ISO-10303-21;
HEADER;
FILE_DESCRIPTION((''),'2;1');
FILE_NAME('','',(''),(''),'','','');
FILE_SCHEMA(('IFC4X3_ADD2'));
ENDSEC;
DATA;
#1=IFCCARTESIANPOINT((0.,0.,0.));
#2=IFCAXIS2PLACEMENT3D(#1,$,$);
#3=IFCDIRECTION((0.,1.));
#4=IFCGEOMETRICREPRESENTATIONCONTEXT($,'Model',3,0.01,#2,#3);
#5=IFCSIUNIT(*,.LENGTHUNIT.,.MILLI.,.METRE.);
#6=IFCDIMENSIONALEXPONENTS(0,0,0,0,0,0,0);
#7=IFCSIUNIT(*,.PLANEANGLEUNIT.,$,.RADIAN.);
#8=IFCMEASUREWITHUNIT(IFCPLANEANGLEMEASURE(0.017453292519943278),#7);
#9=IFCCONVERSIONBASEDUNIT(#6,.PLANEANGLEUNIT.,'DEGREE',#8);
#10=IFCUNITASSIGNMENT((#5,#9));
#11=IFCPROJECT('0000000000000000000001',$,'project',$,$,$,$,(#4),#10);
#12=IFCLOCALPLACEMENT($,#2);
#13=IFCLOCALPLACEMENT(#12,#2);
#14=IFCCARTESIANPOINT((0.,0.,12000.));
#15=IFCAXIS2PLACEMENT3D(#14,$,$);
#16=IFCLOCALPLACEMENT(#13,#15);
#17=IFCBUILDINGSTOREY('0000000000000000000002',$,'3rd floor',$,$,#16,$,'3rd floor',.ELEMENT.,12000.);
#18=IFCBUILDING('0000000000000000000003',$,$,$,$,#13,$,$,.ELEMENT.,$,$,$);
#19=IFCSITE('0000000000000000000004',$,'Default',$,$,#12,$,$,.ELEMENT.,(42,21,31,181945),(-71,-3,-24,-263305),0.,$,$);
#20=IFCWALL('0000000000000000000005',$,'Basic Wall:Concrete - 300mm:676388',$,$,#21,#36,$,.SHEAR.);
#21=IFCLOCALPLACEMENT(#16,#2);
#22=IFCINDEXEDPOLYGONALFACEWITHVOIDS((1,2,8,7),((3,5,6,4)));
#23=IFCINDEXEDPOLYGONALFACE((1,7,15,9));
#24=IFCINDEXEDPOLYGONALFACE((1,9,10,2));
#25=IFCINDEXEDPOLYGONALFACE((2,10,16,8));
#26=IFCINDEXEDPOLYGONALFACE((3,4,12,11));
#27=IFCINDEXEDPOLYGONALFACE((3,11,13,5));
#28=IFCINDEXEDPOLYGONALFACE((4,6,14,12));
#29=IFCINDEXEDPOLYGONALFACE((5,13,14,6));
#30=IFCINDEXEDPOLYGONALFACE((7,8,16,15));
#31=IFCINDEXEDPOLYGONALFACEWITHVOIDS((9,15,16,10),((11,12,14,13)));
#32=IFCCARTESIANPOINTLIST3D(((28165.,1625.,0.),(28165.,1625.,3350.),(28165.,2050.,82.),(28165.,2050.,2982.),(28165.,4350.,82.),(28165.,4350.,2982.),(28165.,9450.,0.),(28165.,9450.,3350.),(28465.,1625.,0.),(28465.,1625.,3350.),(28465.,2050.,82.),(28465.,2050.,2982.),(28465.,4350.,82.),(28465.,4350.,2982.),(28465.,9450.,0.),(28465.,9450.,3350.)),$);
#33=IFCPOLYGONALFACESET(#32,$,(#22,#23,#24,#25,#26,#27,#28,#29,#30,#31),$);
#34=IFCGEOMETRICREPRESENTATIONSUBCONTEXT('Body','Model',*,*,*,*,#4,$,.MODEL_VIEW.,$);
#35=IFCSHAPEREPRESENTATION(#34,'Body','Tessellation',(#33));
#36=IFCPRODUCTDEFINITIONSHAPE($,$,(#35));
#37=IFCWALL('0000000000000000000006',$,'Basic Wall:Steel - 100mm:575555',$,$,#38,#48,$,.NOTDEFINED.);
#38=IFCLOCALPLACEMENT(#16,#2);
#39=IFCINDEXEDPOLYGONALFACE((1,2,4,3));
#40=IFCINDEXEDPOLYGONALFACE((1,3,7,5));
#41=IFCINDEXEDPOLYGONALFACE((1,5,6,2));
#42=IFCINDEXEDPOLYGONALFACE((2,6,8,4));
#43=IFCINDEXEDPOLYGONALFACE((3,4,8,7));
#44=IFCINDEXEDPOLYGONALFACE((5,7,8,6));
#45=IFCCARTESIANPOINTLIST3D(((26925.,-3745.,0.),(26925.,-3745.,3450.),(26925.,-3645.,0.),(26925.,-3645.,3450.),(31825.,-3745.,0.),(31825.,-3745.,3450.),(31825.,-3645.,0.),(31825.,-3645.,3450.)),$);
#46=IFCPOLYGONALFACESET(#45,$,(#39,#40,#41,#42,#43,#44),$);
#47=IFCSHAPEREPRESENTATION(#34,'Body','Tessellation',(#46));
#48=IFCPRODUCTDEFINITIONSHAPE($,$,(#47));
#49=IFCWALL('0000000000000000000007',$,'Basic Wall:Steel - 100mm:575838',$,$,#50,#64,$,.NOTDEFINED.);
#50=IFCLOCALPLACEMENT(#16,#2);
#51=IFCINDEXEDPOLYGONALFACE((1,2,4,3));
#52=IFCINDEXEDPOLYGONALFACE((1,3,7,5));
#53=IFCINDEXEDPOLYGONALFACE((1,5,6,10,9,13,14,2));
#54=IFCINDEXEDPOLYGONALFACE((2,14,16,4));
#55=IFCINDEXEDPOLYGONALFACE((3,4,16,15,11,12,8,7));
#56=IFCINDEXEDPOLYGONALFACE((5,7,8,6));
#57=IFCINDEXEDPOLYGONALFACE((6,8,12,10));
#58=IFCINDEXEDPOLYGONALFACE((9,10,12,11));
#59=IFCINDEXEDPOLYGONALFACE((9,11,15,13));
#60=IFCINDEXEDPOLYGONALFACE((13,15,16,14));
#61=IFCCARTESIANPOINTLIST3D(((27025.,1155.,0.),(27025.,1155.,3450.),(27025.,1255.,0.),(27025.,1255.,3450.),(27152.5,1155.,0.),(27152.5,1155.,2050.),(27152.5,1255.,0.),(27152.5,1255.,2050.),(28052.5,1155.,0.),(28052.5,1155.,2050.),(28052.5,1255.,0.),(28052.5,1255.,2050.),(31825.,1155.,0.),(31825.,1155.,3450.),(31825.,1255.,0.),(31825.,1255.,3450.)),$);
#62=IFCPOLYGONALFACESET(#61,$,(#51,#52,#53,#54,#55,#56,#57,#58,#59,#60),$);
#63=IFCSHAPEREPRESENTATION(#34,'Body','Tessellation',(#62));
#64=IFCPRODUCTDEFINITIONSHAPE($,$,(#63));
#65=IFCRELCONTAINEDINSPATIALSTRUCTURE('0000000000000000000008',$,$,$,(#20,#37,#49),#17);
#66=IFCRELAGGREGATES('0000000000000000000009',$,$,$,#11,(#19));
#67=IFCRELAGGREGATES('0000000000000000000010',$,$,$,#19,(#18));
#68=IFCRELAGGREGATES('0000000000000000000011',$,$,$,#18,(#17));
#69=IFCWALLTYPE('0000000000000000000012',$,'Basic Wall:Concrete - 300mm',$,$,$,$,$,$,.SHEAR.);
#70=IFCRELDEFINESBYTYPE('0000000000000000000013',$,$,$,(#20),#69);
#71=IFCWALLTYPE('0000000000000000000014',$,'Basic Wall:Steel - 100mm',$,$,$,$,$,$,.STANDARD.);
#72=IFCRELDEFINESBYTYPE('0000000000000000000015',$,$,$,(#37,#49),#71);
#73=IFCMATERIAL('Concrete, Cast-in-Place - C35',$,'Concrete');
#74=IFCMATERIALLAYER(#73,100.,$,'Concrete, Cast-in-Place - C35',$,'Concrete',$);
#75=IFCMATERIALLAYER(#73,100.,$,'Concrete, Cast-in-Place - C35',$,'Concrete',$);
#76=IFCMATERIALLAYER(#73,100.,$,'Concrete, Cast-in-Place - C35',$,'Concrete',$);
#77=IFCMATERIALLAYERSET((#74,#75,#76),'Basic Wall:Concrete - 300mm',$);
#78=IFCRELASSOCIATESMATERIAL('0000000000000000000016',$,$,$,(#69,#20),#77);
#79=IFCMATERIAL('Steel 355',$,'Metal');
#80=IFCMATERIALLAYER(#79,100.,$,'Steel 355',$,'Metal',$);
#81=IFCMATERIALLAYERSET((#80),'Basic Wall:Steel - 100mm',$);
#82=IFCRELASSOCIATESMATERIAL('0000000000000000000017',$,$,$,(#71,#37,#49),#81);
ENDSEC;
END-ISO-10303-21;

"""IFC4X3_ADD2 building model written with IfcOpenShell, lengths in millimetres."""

from ifc_helpers import new_model, entity, si_unit, converted_unit, direction, frame, frame_2d, origin, place, context, subcontext, project, spatial, rectangle, extrude, material, layer, layer_set, type_object, element, save


model = new_model("IFC4X3_ADD2")

# Units and contexts
model_context = context("Model", 3, precision=0.01, world=origin(), true_north=direction((0.0, 1.0)))
body_context = subcontext(model_context, "Body", "Model", "MODEL_VIEW")
ifc_project = project(units=[si_unit("LENGTHUNIT", "METRE", prefix="MILLI"), converted_unit("PLANEANGLEUNIT", "DEGREE", entity("IfcPlaneAngleMeasure", 0.017453292519943278), si_unit("PLANEANGLEUNIT", "RADIAN"), dimensions=[0, 0, 0, 0, 0, 0, 0])], contexts=[model_context])

# Site, building, storey
site_placement = place(None, origin())
site = spatial("IfcSite", under=ifc_project, at=site_placement, Name="Default", CompositionType="ELEMENT", RefLatitude=(42, 21, 31, 181945), RefLongitude=(-71, -3, -24, -263305), RefElevation=0.0)
building_placement = place(site_placement, origin())
building = spatial("IfcBuilding", under=site, at=building_placement, CompositionType="ELEMENT")
storey_placement = place(building_placement, frame((0.0, 0.0, 12000.0)))
storey = spatial("IfcBuildingStorey", under=building, at=storey_placement, Name="3rd floor", LongName="3rd floor", CompositionType="ELEMENT", Elevation=12000.0)

# Shared definitions
ifc_material_1 = material(Name="Concrete, Cast-in-Place - C35", Category="Concrete")
ifc_layer_1 = layer(ifc_material_1, 100.0, Name="Concrete, Cast-in-Place - C35", Category="Concrete")
ifc_layer_2 = layer(ifc_material_1, 100.0, Name="Concrete, Cast-in-Place - C35", Category="Concrete")
ifc_layer_3 = layer(ifc_material_1, 100.0, Name="Concrete, Cast-in-Place - C35", Category="Concrete")
ifc_layer_set_1 = layer_set([ifc_layer_1, ifc_layer_2, ifc_layer_3], Name="Basic Wall:Concrete - 300mm")
wall_type_1 = type_object("IfcWallType", Name="Basic Wall:Concrete - 300mm", PredefinedType="SHEAR", material=ifc_layer_set_1)

# Wall, opening
wall_1_placement = place(storey_placement, frame((28315.0, 1625.0, 0.0), z_axis=(0.0, 0.0, 1.0), x_axis=(0.0, 1.0, 0.0)))
wall_1 = element("IfcWall", 1, at=wall_1_placement, inside=storey, type_object=wall_type_1, material=ifc_layer_set_1, Name="Basic Wall:Concrete - 300mm:676388", PredefinedType="SHEAR", context=body_context, shape_type="SweptSolid", body=[
    extrude(rectangle(XDim=7825.0, YDim=300.0, at=frame_2d((3912.5, 0.0), x_axis=(-1.0, 0.0))), origin(), (0.0, 0.0, 1.0), 3350.0),
])
opening_1_placement = place(wall_1_placement, frame((-1625.0, 28315.0, 82.0)))
element("IfcOpeningElement", 2, at=opening_1_placement, cuts=wall_1, PredefinedType="OPENING", context=body_context, shape_type="SweptSolid", body=[
    extrude(rectangle(XDim=2900.0, YDim=2300.0, at=frame_2d((0.0, 0.0), x_axis=(0.0, 1.0))), frame((3200.0, -28615.0, 1450.0), z_axis=(0.0, 1.0, 0.0), x_axis=(-1.0, 0.0, 0.0)), (0.0, 0.0, 1.0), 600.0),
])

# Shared definitions
ifc_material_2 = material(Name="Steel 355", Category="Metal")
ifc_layer_4 = layer(ifc_material_2, 100.0, Name="Steel 355", Category="Metal")
ifc_layer_set_2 = layer_set([ifc_layer_4], Name="Basic Wall:Steel - 100mm")
wall_type_2 = type_object("IfcWallType", Name="Basic Wall:Steel - 100mm", PredefinedType="STANDARD", material=ifc_layer_set_2)

# Wall
wall_2_placement = place(storey_placement, frame((31825.0, -3695.0, 0.0), z_axis=(0.0, 0.0, 1.0), x_axis=(-1.0, 0.0, 0.0)))
element("IfcWall", 3, at=wall_2_placement, inside=storey, type_object=wall_type_2, material=ifc_layer_set_2, Name="Basic Wall:Steel - 100mm:575555", PredefinedType="NOTDEFINED", context=body_context, shape_type="SweptSolid", body=[
    extrude(rectangle(XDim=4900.0, YDim=100.0, at=frame_2d((2450.0, 0.0), x_axis=(-1.0, 0.0))), origin(), (0.0, 0.0, 1.0), 3450.0),
])

# Wall, opening
wall_3_placement = place(storey_placement, frame((31825.0, 1205.0, 0.0), z_axis=(0.0, 0.0, 1.0), x_axis=(-1.0, 0.0, 0.0)))
wall_3 = element("IfcWall", 4, at=wall_3_placement, inside=storey, type_object=wall_type_2, material=ifc_layer_set_2, Name="Basic Wall:Steel - 100mm:575838", PredefinedType="NOTDEFINED", context=body_context, shape_type="SweptSolid", body=[
    extrude(rectangle(XDim=4800.0, YDim=100.0, at=frame_2d((2400.0, 0.0), x_axis=(-1.0, 0.0))), origin(), (0.0, 0.0, 1.0), 3450.0),
])
opening_2_placement = place(wall_3_placement, frame((4672.5, 50.0, 0.0)))
element("IfcOpeningElement", 5, at=opening_2_placement, cuts=wall_3, PredefinedType="OPENING", context=body_context, shape_type="SweptSolid", body=[
    extrude(rectangle(XDim=2050.0, YDim=900.0, at=frame_2d((0.0, 0.0), x_axis=(1.0, 0.0))), frame((-450.0, -100.0, 1025.0), z_axis=(0.0, 1.0, 0.0), x_axis=(0.0, 0.0, -1.0)), (0.0, 0.0, 1.0), 100.0),
])

save(model, "model.ifc")
